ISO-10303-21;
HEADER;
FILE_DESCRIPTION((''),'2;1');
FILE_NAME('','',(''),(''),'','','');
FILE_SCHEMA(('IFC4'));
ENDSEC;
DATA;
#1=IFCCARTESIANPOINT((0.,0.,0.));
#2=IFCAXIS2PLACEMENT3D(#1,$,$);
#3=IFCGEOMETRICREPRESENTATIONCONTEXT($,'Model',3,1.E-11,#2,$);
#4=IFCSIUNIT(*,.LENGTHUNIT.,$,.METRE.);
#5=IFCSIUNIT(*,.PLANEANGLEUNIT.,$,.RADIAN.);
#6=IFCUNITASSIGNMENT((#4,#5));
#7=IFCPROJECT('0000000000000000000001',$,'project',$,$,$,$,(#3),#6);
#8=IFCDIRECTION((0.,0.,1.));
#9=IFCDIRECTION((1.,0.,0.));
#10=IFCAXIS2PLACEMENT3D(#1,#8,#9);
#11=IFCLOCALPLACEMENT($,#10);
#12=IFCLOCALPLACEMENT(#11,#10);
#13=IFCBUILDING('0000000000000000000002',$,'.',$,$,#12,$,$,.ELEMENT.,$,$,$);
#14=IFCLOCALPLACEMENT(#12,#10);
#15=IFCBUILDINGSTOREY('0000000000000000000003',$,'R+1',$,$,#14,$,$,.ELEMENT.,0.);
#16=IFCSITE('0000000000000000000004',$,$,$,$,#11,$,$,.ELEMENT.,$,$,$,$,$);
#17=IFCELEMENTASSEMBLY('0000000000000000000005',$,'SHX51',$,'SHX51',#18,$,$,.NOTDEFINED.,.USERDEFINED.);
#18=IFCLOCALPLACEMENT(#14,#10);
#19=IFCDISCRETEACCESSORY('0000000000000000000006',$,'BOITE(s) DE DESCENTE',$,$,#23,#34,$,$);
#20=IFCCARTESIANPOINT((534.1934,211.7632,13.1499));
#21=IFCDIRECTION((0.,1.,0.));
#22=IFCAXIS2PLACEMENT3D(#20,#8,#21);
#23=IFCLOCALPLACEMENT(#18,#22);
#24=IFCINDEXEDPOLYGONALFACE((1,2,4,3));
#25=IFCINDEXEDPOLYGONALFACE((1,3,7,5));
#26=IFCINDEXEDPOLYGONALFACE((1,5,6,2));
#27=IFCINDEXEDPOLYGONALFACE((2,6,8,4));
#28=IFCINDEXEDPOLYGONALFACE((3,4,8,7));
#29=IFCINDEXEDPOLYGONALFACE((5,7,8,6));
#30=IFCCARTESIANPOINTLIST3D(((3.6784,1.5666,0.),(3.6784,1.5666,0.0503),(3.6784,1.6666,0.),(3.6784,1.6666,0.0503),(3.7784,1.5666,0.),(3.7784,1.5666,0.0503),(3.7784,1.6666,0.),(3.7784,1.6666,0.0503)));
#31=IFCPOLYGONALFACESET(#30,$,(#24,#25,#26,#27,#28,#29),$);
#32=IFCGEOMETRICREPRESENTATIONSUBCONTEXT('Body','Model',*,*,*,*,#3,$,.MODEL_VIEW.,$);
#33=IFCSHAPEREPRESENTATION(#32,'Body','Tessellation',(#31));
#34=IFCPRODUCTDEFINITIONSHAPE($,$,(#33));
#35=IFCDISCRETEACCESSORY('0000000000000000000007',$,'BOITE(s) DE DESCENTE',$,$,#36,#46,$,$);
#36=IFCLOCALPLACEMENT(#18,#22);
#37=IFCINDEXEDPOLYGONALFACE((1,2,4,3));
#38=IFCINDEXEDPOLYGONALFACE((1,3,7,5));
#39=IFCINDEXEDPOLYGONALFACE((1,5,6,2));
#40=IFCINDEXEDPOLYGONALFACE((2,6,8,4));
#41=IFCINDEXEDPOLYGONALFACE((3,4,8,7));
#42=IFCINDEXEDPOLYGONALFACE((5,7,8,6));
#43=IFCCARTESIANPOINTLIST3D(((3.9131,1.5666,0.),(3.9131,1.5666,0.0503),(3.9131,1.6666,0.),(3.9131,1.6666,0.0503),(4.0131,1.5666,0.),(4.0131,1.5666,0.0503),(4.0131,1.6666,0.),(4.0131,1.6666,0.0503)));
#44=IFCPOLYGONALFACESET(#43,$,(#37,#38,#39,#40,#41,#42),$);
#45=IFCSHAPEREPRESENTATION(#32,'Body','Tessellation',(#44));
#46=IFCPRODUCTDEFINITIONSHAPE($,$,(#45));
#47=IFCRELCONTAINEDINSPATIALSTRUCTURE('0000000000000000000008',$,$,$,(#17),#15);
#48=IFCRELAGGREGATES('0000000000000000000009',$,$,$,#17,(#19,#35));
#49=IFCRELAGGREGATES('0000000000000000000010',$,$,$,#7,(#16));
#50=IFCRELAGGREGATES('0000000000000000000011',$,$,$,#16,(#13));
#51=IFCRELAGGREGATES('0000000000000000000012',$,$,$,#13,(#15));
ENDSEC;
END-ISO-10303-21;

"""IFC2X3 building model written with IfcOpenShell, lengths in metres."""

from ifc_helpers import new_model, si_unit, frame, origin, origin_with_axes, place, context, subcontext, project, spatial, polyline, outline, extrude, element, aggregate, save


model = new_model("IFC2X3")

# Units and contexts
model_context = context("Model", 3, precision=1e-11, world=origin())
body_context = subcontext(model_context, "Body", "Model", "MODEL_VIEW")
ifc_project = project(units=[si_unit("LENGTHUNIT", "METRE"), si_unit("PLANEANGLEUNIT", "RADIAN")], contexts=[model_context])

# Site, building, storey
site_placement = place(None, origin_with_axes())
site = spatial("IfcSite", under=ifc_project, at=site_placement, CompositionType="ELEMENT")
building_placement = place(site_placement, origin_with_axes())
building = spatial("IfcBuilding", under=site, at=building_placement, Name=".", CompositionType="ELEMENT")
storey_placement = place(building_placement, origin_with_axes())
storey = spatial("IfcBuildingStorey", under=building, at=storey_placement, Name="R+1", CompositionType="ELEMENT", Elevation=0.0)

# Element assembly, discrete accessories
assembly_1_placement = place(storey_placement, origin_with_axes())
assembly_1 = element("IfcElementAssembly", 1, at=assembly_1_placement, inside=storey, Name="SHX51", ObjectType="SHX51", AssemblyPlace="NOTDEFINED", PredefinedType="USERDEFINED")
discrete_accessory_1_placement = place(assembly_1_placement, frame((534.1934, 211.7632, 13.1499), z_axis=(0.0, 0.0, 1.0), x_axis=(0.0, 1.0, 0.0)))
discrete_accessory_1 = element("IfcDiscreteAccessory", 2, at=discrete_accessory_1_placement, Name="BOITE(s) DE DESCENTE", context=body_context, shape_type="SweptSolid", body=[
    extrude(outline(polyline([(1.5666, -3.6784), (1.5666, -3.7784), (1.6666, -3.7784), (1.6666, -3.6784), (1.5666, -3.6784)])), frame((0.0, 0.0, 0.0), z_axis=(0.0, 0.0, 1.0), x_axis=(0.0, 1.0, 0.0)), (0.0, 0.0, 1.0), 0.0503),
])
discrete_accessory_2_placement = place(assembly_1_placement, frame((534.1934, 211.7632, 13.1499), z_axis=(0.0, 0.0, 1.0), x_axis=(0.0, 1.0, 0.0)))
discrete_accessory_2 = element("IfcDiscreteAccessory", 3, at=discrete_accessory_2_placement, Name="BOITE(s) DE DESCENTE", context=body_context, shape_type="SweptSolid", body=[
    extrude(outline(polyline([(1.5666, -3.9131), (1.5666, -4.0131), (1.6666, -4.0131), (1.6666, -3.9131), (1.5666, -3.9131)])), frame((0.0, 0.0, 0.0), z_axis=(0.0, 0.0, 1.0), x_axis=(0.0, 1.0, 0.0)), (0.0, 0.0, 1.0), 0.0503),
])
aggregate(assembly_1, [discrete_accessory_1, discrete_accessory_2])

save(model, "model.ifc")
